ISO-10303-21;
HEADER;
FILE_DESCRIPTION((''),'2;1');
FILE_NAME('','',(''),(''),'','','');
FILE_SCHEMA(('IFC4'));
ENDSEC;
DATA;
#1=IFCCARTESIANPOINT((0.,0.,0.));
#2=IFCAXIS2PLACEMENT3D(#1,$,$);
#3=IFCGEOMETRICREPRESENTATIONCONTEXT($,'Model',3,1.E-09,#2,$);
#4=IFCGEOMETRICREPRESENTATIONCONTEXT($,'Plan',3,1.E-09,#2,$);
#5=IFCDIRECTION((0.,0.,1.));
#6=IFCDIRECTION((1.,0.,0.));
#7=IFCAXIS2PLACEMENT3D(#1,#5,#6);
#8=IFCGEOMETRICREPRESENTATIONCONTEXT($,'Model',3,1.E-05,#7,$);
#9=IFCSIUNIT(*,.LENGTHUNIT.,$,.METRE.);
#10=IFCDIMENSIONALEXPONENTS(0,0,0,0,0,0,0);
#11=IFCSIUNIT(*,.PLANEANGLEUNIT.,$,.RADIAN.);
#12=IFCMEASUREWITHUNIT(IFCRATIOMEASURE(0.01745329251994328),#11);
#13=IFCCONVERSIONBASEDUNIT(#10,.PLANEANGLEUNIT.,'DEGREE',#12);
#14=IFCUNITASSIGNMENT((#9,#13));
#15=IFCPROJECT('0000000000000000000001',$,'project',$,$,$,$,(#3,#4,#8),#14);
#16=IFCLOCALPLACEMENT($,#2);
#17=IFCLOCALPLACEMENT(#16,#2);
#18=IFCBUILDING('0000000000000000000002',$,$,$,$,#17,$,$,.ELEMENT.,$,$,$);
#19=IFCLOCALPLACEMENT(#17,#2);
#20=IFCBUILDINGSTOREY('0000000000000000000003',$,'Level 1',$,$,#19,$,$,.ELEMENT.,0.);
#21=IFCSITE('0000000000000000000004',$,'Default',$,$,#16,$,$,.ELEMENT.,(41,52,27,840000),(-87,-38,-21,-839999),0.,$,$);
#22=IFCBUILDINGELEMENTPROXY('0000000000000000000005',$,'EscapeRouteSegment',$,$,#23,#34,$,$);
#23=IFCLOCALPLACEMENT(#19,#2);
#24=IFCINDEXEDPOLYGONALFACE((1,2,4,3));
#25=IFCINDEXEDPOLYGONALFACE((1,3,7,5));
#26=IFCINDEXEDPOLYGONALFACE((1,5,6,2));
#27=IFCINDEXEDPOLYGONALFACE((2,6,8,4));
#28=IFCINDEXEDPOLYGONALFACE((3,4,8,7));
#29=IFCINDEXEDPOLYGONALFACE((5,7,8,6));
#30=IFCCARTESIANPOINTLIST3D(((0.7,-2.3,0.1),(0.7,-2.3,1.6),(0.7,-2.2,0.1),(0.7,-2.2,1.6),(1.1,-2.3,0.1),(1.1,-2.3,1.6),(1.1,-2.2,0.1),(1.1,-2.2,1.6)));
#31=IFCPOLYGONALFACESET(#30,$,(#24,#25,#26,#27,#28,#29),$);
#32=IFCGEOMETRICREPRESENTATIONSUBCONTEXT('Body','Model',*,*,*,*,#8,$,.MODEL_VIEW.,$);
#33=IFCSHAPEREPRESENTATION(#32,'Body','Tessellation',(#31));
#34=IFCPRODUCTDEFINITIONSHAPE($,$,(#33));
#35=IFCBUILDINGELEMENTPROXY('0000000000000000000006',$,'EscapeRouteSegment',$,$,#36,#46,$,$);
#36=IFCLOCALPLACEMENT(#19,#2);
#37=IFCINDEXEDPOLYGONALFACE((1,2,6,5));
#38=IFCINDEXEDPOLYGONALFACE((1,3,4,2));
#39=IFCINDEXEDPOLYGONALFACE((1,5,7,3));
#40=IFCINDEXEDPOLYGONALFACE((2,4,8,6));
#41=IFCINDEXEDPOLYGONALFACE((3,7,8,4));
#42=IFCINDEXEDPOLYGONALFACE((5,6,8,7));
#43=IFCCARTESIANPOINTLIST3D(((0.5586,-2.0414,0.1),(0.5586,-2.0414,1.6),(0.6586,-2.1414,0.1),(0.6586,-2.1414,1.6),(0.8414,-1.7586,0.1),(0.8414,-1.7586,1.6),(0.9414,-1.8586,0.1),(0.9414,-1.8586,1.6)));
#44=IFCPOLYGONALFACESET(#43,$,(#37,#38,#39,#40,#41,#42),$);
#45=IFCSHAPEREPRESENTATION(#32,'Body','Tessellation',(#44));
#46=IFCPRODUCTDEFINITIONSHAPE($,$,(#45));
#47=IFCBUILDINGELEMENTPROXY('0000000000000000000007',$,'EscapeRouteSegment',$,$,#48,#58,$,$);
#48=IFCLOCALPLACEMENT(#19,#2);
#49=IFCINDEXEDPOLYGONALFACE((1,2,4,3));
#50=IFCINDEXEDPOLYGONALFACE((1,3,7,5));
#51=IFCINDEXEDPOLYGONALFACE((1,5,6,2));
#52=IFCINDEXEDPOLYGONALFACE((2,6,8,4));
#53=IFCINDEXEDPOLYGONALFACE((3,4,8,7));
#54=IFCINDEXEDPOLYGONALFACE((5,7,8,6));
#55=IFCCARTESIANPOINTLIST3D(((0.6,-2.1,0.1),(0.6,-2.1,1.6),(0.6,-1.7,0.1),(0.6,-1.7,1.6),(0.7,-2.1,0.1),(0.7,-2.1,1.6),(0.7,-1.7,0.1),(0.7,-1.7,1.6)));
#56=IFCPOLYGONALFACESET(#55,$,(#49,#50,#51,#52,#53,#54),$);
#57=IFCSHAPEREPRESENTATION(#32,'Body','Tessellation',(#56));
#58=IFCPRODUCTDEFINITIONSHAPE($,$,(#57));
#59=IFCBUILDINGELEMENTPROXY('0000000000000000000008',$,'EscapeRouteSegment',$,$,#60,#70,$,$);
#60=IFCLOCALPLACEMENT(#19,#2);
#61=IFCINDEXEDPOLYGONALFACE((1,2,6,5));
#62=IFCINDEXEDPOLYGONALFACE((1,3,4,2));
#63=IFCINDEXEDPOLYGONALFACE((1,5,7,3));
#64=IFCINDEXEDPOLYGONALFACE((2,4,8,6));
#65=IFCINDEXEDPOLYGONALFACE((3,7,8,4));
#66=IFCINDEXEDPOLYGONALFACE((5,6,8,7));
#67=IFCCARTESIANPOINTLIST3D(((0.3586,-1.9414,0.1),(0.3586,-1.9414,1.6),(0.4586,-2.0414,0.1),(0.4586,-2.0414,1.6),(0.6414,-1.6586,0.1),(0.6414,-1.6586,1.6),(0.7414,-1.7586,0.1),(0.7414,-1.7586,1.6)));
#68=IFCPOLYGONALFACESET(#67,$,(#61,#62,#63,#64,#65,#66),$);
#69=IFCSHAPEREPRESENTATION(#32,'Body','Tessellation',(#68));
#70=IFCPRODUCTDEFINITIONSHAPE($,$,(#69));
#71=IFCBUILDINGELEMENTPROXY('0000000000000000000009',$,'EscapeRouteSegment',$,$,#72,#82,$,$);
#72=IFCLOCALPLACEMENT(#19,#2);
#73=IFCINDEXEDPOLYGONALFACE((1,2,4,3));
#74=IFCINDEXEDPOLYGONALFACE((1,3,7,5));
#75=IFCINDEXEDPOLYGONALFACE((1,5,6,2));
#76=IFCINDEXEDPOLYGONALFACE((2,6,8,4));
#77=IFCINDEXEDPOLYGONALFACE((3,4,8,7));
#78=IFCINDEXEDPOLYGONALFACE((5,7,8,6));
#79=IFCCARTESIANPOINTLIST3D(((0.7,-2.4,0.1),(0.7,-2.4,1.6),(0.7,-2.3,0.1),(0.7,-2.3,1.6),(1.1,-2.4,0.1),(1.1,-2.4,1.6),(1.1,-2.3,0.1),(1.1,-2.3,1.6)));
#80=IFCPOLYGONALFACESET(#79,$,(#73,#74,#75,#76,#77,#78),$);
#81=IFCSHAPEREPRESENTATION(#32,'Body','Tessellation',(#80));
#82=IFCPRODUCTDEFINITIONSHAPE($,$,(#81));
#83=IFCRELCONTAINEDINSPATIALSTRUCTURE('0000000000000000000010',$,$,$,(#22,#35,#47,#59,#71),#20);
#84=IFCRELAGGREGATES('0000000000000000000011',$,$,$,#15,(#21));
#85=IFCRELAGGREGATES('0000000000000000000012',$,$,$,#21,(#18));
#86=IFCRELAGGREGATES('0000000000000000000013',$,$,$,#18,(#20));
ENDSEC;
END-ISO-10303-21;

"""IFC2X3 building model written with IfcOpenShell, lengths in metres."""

from ifc_helpers import new_model, entity, si_unit, converted_unit, frame, origin, origin_with_axes, place, context, subcontext, project, spatial, polyline, outline, extrude, element, save


model = new_model("IFC2X3")

# Units and contexts
model_context_1 = context("Model", 3, precision=1e-09, world=origin())
plan_context = context("Plan", 3, precision=1e-09, world=origin())
model_context_2 = context("Model", 3, precision=1e-05, world=origin_with_axes())
body_context = subcontext(model_context_2, "Body", "Model", "MODEL_VIEW")
ifc_project = project(units=[si_unit("LENGTHUNIT", "METRE"), converted_unit("PLANEANGLEUNIT", "DEGREE", entity("IfcRatioMeasure", 0.01745329251994328), si_unit("PLANEANGLEUNIT", "RADIAN"), dimensions=[0, 0, 0, 0, 0, 0, 0])], contexts=[model_context_1, plan_context, model_context_2])

# Site, building, storey
site_placement = place(None, origin())
site = spatial("IfcSite", under=ifc_project, at=site_placement, Name="Default", CompositionType="ELEMENT", RefLatitude=(41, 52, 27, 840000), RefLongitude=(-87, -38, -21, -839999), RefElevation=0.0)
building_placement = place(site_placement, origin())
building = spatial("IfcBuilding", under=site, at=building_placement, CompositionType="ELEMENT")
storey_placement = place(building_placement, origin())
storey = spatial("IfcBuildingStorey", under=building, at=storey_placement, Name="Level 1", CompositionType="ELEMENT", Elevation=0.0)

# Building element proxies
proxy_1_placement = place(storey_placement, frame((0.9, -2.3, 0.1), z_axis=(0.0, 0.0, 1.0), x_axis=(0.0, 1.0, 0.0)))
element("IfcBuildingElementProxy", 1, at=proxy_1_placement, inside=storey, Name="EscapeRouteSegment", context=body_context, shape_type="SweptSolid", body=[
    extrude(outline(polyline([(0.0, -0.2), (0.0, 0.2), (0.1, 0.2), (0.1, -0.2), (0.0, -0.2)])), origin_with_axes(), (0.0, 0.0, 1.0), 1.5),
])
proxy_2_placement = place(storey_placement, frame((0.8, -2.0, 0.1), z_axis=(0.0, 0.0, 1.0), x_axis=(-0.707107, 0.707107, 0.0)))
element("IfcBuildingElementProxy", 2, at=proxy_2_placement, inside=storey, Name="EscapeRouteSegment", context=body_context, shape_type="SweptSolid", body=[
    extrude(outline(polyline([(0.0, -0.2), (0.0, 0.2), (0.1414, 0.2), (0.1414, -0.2), (0.0, -0.2)])), origin_with_axes(), (0.0, 0.0, 1.0), 1.5),
])
proxy_3_placement = place(storey_placement, frame((0.7, -1.9, 0.1), z_axis=(0.0, 0.0, 1.0), x_axis=(-1.0, 0.0, 0.0)))
element("IfcBuildingElementProxy", 3, at=proxy_3_placement, inside=storey, Name="EscapeRouteSegment", context=body_context, shape_type="SweptSolid", body=[
    extrude(outline(polyline([(0.0, -0.2), (0.0, 0.2), (0.1, 0.2), (0.1, -0.2), (0.0, -0.2)])), origin_with_axes(), (0.0, 0.0, 1.0), 1.5),
])
proxy_4_placement = place(storey_placement, frame((0.6, -1.9, 0.1), z_axis=(0.0, 0.0, 1.0), x_axis=(-0.707107, 0.707107, 0.0)))
element("IfcBuildingElementProxy", 4, at=proxy_4_placement, inside=storey, Name="EscapeRouteSegment", context=body_context, shape_type="SweptSolid", body=[
    extrude(outline(polyline([(0.0, -0.2), (0.0, 0.2), (0.1414, 0.2), (0.1414, -0.2), (0.0, -0.2)])), origin_with_axes(), (0.0, 0.0, 1.0), 1.5),
])
proxy_5_placement = place(storey_placement, frame((0.9, -2.4, 0.1), z_axis=(0.0, 0.0, 1.0), x_axis=(0.0, 1.0, 0.0)))
element("IfcBuildingElementProxy", 5, at=proxy_5_placement, inside=storey, Name="EscapeRouteSegment", context=body_context, shape_type="SweptSolid", body=[
    extrude(outline(polyline([(0.0, -0.2), (0.0, 0.2), (0.1, 0.2), (0.1, -0.2), (0.0, -0.2)])), origin_with_axes(), (0.0, 0.0, 1.0), 1.5),
])

save(model, "model.ifc")
